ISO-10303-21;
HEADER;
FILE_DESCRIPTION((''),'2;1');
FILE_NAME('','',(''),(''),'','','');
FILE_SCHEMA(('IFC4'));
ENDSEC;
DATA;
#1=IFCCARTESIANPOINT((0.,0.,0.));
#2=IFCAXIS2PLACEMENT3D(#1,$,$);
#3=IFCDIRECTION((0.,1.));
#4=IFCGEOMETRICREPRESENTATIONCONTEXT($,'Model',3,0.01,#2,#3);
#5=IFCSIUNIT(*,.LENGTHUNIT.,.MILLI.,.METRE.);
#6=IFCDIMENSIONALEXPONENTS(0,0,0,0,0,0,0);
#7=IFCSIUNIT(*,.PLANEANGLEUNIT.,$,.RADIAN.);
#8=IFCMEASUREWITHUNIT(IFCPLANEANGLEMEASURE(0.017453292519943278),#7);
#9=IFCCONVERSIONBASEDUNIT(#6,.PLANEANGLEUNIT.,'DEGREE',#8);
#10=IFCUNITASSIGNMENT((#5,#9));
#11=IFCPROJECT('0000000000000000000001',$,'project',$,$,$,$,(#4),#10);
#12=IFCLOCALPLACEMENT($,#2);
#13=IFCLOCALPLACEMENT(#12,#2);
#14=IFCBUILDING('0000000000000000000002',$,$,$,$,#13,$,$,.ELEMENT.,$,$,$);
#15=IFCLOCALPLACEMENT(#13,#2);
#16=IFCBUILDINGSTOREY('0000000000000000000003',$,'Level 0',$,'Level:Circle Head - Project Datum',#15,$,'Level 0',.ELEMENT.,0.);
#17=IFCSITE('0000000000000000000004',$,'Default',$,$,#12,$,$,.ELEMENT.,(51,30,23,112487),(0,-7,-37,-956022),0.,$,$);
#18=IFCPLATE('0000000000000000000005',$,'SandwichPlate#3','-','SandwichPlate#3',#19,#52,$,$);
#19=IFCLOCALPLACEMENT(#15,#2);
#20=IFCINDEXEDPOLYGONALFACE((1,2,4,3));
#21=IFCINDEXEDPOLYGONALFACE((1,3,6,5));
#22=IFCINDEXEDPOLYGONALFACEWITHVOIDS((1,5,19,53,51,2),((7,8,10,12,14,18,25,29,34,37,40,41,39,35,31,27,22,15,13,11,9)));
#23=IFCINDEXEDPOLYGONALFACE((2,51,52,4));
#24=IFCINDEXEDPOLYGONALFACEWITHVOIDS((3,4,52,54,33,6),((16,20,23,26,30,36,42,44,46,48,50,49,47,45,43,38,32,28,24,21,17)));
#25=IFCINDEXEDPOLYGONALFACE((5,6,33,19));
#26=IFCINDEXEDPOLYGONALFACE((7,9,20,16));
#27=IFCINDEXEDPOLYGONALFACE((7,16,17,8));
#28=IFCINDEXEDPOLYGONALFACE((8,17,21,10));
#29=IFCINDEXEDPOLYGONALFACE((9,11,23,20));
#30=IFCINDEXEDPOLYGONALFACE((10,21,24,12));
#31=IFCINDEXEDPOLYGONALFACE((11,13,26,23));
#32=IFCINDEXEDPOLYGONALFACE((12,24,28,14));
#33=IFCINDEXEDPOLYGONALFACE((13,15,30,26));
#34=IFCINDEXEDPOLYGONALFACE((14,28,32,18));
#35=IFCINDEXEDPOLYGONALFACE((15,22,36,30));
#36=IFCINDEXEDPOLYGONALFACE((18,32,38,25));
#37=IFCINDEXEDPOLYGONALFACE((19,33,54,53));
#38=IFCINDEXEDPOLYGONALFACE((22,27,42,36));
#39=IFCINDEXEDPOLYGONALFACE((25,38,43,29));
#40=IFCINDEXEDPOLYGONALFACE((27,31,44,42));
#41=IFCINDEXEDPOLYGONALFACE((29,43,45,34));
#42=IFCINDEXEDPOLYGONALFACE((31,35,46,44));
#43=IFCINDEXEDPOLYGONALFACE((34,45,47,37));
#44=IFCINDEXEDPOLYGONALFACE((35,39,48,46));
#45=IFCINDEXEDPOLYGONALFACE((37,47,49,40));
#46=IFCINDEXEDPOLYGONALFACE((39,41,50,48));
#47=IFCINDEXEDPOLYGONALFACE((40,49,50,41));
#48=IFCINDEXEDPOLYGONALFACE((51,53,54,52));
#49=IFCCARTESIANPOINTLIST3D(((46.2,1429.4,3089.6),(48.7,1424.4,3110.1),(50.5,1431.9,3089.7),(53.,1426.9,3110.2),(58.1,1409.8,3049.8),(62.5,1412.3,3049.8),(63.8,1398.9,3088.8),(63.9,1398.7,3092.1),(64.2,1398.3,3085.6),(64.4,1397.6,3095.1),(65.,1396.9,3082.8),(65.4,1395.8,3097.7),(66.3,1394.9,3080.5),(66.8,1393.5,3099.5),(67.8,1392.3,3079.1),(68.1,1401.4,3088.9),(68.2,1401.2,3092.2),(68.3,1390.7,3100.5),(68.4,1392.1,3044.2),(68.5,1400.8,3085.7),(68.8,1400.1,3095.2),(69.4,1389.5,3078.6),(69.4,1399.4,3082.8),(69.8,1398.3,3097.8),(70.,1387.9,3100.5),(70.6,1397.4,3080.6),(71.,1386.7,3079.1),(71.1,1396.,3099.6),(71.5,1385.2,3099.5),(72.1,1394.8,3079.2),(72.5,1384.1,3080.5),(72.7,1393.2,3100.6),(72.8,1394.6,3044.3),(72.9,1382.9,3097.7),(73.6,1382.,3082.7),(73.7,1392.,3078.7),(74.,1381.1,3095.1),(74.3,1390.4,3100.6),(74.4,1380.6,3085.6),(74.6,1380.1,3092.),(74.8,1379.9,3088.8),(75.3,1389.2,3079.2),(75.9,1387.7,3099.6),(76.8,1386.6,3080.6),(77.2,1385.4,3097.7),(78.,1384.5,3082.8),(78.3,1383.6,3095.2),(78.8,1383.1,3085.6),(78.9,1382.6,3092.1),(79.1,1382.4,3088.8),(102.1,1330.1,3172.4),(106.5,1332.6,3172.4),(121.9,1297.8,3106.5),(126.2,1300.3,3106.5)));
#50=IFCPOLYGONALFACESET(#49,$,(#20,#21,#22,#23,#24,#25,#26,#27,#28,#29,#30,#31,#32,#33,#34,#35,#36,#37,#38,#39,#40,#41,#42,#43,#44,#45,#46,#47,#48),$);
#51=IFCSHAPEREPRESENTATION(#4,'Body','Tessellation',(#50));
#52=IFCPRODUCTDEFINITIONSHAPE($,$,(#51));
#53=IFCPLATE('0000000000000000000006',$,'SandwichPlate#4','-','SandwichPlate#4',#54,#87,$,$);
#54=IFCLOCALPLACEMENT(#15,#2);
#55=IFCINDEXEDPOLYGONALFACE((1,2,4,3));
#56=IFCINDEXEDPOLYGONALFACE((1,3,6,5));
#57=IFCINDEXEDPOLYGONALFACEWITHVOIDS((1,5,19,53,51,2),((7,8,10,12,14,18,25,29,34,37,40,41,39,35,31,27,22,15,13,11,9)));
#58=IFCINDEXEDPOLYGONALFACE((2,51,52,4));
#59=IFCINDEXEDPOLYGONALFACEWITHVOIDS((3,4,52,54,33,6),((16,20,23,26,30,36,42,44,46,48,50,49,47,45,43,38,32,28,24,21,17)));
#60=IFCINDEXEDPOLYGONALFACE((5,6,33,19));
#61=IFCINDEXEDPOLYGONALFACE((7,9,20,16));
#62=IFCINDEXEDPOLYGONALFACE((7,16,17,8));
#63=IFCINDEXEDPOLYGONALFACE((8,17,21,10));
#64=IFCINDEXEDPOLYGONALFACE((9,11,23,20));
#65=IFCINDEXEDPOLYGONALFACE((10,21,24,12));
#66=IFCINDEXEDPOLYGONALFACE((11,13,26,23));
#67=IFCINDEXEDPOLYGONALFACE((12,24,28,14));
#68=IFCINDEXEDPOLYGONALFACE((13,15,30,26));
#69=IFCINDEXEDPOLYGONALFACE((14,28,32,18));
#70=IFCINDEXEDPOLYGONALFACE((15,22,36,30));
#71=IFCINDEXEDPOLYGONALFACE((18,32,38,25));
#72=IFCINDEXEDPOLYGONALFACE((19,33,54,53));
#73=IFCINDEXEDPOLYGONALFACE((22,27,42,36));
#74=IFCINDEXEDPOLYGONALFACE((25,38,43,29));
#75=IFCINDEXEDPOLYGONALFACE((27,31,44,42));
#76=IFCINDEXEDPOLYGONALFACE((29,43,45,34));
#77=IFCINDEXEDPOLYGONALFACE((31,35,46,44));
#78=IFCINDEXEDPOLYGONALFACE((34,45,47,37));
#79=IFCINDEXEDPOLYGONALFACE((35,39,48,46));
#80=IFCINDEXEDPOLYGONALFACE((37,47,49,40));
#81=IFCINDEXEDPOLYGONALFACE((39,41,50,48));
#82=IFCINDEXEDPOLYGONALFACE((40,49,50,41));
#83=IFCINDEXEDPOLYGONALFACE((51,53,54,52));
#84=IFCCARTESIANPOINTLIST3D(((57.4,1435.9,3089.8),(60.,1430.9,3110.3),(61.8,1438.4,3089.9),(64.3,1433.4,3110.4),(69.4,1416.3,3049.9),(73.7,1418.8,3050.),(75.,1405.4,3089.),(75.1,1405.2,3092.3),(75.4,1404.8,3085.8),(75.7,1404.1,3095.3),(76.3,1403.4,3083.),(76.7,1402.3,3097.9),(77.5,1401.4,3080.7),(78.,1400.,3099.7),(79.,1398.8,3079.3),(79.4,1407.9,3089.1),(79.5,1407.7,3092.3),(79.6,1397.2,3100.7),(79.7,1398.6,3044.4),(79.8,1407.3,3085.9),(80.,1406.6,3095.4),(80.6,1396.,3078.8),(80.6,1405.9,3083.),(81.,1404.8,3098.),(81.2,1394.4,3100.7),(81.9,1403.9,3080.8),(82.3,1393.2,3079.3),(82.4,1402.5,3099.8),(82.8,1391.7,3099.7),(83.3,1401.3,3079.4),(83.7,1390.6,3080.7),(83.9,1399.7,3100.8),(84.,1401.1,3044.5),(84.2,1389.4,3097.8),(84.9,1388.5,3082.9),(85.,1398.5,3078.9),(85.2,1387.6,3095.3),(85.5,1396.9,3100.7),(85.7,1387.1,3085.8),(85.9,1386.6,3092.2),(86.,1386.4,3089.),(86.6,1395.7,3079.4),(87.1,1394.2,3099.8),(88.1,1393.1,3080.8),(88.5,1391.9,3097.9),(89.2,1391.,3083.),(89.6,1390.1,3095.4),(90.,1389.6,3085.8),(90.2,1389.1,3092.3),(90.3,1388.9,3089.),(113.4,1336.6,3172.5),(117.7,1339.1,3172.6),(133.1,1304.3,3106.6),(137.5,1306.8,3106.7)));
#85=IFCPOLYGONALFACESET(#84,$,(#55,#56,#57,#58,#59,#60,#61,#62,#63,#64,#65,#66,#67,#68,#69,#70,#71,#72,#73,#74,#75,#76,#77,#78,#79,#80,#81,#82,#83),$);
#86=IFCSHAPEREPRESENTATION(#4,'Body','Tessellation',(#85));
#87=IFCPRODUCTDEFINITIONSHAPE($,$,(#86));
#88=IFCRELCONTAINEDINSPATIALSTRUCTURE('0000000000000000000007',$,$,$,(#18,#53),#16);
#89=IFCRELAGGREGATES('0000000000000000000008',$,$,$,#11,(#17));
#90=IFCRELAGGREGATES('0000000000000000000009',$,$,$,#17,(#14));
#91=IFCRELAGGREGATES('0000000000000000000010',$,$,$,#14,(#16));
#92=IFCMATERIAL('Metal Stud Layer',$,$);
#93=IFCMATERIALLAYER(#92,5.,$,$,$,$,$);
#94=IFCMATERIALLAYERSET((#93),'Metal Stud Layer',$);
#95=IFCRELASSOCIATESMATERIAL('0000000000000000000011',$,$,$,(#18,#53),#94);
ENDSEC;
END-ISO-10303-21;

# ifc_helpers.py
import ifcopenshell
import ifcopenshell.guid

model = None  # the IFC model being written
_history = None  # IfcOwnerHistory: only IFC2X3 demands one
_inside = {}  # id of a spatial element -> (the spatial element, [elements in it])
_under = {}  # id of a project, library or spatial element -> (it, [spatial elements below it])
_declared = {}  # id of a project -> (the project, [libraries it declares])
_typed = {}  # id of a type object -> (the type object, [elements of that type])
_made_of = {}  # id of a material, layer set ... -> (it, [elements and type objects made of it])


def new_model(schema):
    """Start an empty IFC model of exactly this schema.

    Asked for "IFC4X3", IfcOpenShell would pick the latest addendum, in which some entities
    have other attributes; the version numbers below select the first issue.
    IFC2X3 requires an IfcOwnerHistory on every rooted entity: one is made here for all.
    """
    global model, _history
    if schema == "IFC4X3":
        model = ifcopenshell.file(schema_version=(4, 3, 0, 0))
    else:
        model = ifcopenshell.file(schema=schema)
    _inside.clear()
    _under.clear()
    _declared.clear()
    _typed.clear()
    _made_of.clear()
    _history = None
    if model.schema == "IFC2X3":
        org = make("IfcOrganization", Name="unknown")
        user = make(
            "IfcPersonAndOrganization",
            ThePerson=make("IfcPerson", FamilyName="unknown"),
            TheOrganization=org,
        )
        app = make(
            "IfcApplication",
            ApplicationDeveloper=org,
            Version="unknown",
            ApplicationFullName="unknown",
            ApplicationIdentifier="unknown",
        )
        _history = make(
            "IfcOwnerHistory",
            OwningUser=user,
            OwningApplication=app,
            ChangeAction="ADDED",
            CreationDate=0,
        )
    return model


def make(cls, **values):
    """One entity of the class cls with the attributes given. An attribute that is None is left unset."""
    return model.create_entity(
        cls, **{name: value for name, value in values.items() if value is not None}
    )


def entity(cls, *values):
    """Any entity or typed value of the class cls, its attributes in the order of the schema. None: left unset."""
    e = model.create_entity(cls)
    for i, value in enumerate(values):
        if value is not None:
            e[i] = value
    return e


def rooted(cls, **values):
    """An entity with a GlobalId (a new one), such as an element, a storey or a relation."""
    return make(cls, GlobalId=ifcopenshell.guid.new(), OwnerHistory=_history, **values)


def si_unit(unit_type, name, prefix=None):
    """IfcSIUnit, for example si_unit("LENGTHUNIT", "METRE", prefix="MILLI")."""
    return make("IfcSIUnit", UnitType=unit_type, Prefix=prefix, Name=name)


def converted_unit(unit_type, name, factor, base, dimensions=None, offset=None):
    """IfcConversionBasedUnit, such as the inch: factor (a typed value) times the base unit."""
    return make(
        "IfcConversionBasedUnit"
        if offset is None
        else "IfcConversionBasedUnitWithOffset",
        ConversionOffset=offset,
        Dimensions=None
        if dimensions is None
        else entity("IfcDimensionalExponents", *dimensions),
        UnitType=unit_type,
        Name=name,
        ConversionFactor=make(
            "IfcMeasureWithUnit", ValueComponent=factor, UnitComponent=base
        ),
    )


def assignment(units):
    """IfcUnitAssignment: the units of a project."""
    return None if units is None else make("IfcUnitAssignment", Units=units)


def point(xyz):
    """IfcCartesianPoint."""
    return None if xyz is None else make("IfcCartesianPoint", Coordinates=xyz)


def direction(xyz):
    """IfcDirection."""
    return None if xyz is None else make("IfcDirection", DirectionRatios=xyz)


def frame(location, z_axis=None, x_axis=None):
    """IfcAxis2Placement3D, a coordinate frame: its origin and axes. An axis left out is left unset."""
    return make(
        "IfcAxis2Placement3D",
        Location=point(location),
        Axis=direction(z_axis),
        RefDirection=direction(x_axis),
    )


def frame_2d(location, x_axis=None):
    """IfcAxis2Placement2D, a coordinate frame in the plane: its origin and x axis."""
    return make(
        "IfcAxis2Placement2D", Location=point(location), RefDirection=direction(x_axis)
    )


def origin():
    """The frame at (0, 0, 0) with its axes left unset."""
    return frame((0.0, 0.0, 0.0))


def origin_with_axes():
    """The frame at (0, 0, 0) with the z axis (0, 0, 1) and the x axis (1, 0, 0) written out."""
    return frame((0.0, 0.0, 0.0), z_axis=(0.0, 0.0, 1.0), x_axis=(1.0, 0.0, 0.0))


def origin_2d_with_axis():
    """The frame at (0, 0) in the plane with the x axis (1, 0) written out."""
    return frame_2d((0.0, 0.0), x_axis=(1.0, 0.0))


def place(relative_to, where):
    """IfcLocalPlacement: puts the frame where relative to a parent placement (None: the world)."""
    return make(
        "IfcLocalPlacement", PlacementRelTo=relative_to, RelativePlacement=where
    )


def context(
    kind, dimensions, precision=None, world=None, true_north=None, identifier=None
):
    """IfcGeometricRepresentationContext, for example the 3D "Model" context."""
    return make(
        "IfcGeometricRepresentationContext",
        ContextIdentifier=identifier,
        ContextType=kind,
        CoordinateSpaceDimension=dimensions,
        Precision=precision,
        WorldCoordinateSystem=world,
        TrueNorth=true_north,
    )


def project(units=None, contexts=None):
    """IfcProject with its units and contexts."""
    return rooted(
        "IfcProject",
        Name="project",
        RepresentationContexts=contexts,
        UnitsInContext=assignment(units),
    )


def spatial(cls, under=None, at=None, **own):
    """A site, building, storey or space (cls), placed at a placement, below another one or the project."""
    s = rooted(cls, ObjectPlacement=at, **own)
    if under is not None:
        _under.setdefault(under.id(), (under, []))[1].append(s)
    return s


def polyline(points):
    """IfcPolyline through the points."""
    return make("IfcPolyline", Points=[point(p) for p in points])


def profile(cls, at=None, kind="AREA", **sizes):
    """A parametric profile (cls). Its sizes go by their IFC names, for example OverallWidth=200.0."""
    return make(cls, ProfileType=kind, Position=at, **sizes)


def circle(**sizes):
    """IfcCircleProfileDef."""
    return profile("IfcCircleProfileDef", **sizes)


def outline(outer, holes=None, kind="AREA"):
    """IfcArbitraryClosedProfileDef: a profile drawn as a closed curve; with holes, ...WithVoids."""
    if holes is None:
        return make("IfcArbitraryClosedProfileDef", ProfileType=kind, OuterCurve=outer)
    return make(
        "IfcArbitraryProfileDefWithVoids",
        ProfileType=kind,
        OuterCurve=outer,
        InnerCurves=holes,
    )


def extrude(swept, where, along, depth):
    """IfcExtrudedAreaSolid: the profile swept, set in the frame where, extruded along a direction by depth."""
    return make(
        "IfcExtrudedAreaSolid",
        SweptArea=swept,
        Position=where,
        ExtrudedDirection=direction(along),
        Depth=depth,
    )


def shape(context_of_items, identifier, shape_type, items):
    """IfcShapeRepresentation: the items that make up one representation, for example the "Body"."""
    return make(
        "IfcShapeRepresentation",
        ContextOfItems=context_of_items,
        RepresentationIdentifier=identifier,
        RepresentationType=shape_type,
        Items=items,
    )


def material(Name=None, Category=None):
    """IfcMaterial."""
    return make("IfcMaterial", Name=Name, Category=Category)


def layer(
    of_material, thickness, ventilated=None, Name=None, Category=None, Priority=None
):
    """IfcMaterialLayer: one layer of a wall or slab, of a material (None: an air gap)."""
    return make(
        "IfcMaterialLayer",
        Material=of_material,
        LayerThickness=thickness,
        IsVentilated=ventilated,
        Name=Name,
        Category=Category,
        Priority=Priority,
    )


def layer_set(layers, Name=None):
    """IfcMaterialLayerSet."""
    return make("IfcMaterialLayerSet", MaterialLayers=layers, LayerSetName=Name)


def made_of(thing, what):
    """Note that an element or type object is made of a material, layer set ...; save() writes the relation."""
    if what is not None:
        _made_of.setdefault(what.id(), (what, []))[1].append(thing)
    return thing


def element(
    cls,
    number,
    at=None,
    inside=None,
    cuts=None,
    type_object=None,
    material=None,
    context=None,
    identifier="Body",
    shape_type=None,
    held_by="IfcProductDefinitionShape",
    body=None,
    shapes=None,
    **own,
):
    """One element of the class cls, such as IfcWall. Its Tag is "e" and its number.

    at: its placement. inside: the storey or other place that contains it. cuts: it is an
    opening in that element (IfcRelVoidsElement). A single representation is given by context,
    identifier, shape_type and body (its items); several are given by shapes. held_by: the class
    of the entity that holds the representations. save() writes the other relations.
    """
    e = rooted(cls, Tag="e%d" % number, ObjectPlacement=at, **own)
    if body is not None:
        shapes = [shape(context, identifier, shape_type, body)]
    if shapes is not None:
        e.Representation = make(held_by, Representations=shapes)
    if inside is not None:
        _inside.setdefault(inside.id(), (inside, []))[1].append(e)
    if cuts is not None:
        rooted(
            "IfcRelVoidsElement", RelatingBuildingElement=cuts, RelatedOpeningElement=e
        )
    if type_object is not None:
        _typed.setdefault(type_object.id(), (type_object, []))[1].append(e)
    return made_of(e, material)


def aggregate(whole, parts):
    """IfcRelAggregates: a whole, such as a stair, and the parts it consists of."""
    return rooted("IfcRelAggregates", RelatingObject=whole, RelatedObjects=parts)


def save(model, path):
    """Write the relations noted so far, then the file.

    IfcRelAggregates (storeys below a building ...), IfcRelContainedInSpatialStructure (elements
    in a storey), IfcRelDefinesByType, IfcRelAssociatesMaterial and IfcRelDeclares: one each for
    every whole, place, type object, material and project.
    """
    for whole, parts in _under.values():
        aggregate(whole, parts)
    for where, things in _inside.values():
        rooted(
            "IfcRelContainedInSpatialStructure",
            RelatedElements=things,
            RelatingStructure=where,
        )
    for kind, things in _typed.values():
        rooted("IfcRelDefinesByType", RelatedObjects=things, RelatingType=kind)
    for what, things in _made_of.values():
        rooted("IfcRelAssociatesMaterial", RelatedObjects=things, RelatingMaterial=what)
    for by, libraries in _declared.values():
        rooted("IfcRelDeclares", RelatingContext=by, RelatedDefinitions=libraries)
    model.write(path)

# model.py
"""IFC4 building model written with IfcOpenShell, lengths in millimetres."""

from ifc_helpers import new_model, entity, si_unit, converted_unit, direction, frame, origin, origin_with_axes, origin_2d_with_axis, place, context, project, spatial, polyline, circle, outline, extrude, material, layer, layer_set, element, save


model = new_model("IFC4")

# Units and contexts
model_context = context("Model", 3, precision=0.01, world=origin(), true_north=direction((0.0, 1.0)))
ifc_project = project(units=[si_unit("LENGTHUNIT", "METRE", prefix="MILLI"), converted_unit("PLANEANGLEUNIT", "DEGREE", entity("IfcPlaneAngleMeasure", 0.017453292519943278), si_unit("PLANEANGLEUNIT", "RADIAN"), dimensions=[0, 0, 0, 0, 0, 0, 0])], contexts=[model_context])

# Site, building, storey
site_placement = place(None, origin())
site = spatial("IfcSite", under=ifc_project, at=site_placement, Name="Default", CompositionType="ELEMENT", RefLatitude=(51, 30, 23, 112487), RefLongitude=(0, -7, -37, -956022), RefElevation=0.0)
building_placement = place(site_placement, origin())
building = spatial("IfcBuilding", under=site, at=building_placement, CompositionType="ELEMENT")
storey_placement = place(building_placement, origin())
storey = spatial("IfcBuildingStorey", under=building, at=storey_placement, Name="Level 0", ObjectType="Level:Circle Head - Project Datum", LongName="Level 0", CompositionType="ELEMENT", Elevation=0.0)

# Plates, openings
ifc_material_1 = material(Name="Metal Stud Layer")
ifc_layer_1 = layer(ifc_material_1, 5.0)
ifc_layer_set_1 = layer_set([ifc_layer_1], Name="Metal Stud Layer")
plate_1_placement = place(storey_placement, frame((62.0, 1403.5, 3036.7), z_axis=(0.865935, 0.499948, 0.014432), x_axis=(-0.259821, 0.424992, 0.867107)))
plate_1 = element("IfcPlate", 1, at=plate_1_placement, inside=storey, material=ifc_layer_set_1, Name="SandwichPlate#3", Description="-", ObjectType="SandwichPlate#3", context=model_context, shape_type="SweptSolid", body=[
    extrude(outline(polyline([(0.0, 0.0), (76.0, 0.0), (76.0, 140.0), (0.0, 140.0), (0.0, 0.0)])), origin_with_axes(), (0.0, 0.0, 1.0), 5.0),
])
opening_1_placement = place(plate_1_placement, frame((0.0, 0.0, 0.0), z_axis=(0.0, 0.0, 1.0), x_axis=(1.0, 0.0, 0.0)))
element("IfcOpeningElement", 2, at=opening_1_placement, cuts=plate_1, ObjectType="Opening", context=model_context, shape_type="SweptSolid", body=[
    extrude(outline(polyline([(0.0, 0.0), (15.0, 0.0), (0.0, 15.0), (0.0, 0.0)])), origin(), (0.0, 0.0, 1.0), 5.0),
])
opening_2_placement = place(plate_1_placement, frame((0.0, 0.0, 0.0), z_axis=(0.0, 0.0, 1.0), x_axis=(1.0, 0.0, 0.0)))
element("IfcOpeningElement", 3, at=opening_2_placement, cuts=plate_1, ObjectType="Opening", context=model_context, shape_type="SweptSolid", body=[
    extrude(outline(polyline([(76.0, 0.0), (76.0, 15.0), (61.0, 0.0), (76.0, 0.0)])), origin(), (0.0, 0.0, 1.0), 5.0),
])
opening_3_placement = place(plate_1_placement, frame((38.0, 40.0, -0.5), z_axis=(0.0, 0.0, 1.0), x_axis=(0.0, 1.0, 0.0)))
element("IfcOpeningElement", 4, at=opening_3_placement, cuts=plate_1, ObjectType="Opening", context=model_context, shape_type="SweptSolid", body=[
    extrude(circle(Radius=11.0, at=origin_2d_with_axis()), origin(), (0.0, 0.0, 1.0), 6.0),
])
plate_2_placement = place(storey_placement, frame((73.3, 1410.0, 3036.9), z_axis=(0.865935, 0.499948, 0.014432), x_axis=(-0.259821, 0.424992, 0.867107)))
plate_2 = element("IfcPlate", 5, at=plate_2_placement, inside=storey, material=ifc_layer_set_1, Name="SandwichPlate#4", Description="-", ObjectType="SandwichPlate#4", context=model_context, shape_type="SweptSolid", body=[
    extrude(outline(polyline([(0.0, 0.0), (76.0, 0.0), (76.0, 140.0), (0.0, 140.0), (0.0, 0.0)])), origin_with_axes(), (0.0, 0.0, 1.0), 5.0),
])
opening_4_placement = place(plate_2_placement, frame((0.0, 0.0, 0.0), z_axis=(0.0, 0.0, 1.0), x_axis=(1.0, 0.0, 0.0)))
element("IfcOpeningElement", 6, at=opening_4_placement, cuts=plate_2, ObjectType="Opening", context=model_context, shape_type="SweptSolid", body=[
    extrude(outline(polyline([(0.0, 0.0), (15.0, 0.0), (0.0, 15.0), (0.0, 0.0)])), origin(), (0.0, 0.0, 1.0), 5.0),
])
opening_5_placement = place(plate_2_placement, frame((0.0, 0.0, 0.0), z_axis=(0.0, 0.0, 1.0), x_axis=(1.0, 0.0, 0.0)))
element("IfcOpeningElement", 7, at=opening_5_placement, cuts=plate_2, ObjectType="Opening", context=model_context, shape_type="SweptSolid", body=[
    extrude(outline(polyline([(76.0, 0.0), (76.0, 15.0), (61.0, 0.0), (76.0, 0.0)])), origin(), (0.0, 0.0, 1.0), 5.0),
])
opening_6_placement = place(plate_2_placement, frame((38.0, 40.0, -0.5), z_axis=(0.0, 0.0, 1.0), x_axis=(0.0, 1.0, 0.0)))
element("IfcOpeningElement", 8, at=opening_6_placement, cuts=plate_2, ObjectType="Opening", context=model_context, shape_type="SweptSolid", body=[
    extrude(circle(Radius=11.0, at=origin_2d_with_axis()), origin(), (0.0, 0.0, 1.0), 6.0),
])

save(model, "model.ifc")
